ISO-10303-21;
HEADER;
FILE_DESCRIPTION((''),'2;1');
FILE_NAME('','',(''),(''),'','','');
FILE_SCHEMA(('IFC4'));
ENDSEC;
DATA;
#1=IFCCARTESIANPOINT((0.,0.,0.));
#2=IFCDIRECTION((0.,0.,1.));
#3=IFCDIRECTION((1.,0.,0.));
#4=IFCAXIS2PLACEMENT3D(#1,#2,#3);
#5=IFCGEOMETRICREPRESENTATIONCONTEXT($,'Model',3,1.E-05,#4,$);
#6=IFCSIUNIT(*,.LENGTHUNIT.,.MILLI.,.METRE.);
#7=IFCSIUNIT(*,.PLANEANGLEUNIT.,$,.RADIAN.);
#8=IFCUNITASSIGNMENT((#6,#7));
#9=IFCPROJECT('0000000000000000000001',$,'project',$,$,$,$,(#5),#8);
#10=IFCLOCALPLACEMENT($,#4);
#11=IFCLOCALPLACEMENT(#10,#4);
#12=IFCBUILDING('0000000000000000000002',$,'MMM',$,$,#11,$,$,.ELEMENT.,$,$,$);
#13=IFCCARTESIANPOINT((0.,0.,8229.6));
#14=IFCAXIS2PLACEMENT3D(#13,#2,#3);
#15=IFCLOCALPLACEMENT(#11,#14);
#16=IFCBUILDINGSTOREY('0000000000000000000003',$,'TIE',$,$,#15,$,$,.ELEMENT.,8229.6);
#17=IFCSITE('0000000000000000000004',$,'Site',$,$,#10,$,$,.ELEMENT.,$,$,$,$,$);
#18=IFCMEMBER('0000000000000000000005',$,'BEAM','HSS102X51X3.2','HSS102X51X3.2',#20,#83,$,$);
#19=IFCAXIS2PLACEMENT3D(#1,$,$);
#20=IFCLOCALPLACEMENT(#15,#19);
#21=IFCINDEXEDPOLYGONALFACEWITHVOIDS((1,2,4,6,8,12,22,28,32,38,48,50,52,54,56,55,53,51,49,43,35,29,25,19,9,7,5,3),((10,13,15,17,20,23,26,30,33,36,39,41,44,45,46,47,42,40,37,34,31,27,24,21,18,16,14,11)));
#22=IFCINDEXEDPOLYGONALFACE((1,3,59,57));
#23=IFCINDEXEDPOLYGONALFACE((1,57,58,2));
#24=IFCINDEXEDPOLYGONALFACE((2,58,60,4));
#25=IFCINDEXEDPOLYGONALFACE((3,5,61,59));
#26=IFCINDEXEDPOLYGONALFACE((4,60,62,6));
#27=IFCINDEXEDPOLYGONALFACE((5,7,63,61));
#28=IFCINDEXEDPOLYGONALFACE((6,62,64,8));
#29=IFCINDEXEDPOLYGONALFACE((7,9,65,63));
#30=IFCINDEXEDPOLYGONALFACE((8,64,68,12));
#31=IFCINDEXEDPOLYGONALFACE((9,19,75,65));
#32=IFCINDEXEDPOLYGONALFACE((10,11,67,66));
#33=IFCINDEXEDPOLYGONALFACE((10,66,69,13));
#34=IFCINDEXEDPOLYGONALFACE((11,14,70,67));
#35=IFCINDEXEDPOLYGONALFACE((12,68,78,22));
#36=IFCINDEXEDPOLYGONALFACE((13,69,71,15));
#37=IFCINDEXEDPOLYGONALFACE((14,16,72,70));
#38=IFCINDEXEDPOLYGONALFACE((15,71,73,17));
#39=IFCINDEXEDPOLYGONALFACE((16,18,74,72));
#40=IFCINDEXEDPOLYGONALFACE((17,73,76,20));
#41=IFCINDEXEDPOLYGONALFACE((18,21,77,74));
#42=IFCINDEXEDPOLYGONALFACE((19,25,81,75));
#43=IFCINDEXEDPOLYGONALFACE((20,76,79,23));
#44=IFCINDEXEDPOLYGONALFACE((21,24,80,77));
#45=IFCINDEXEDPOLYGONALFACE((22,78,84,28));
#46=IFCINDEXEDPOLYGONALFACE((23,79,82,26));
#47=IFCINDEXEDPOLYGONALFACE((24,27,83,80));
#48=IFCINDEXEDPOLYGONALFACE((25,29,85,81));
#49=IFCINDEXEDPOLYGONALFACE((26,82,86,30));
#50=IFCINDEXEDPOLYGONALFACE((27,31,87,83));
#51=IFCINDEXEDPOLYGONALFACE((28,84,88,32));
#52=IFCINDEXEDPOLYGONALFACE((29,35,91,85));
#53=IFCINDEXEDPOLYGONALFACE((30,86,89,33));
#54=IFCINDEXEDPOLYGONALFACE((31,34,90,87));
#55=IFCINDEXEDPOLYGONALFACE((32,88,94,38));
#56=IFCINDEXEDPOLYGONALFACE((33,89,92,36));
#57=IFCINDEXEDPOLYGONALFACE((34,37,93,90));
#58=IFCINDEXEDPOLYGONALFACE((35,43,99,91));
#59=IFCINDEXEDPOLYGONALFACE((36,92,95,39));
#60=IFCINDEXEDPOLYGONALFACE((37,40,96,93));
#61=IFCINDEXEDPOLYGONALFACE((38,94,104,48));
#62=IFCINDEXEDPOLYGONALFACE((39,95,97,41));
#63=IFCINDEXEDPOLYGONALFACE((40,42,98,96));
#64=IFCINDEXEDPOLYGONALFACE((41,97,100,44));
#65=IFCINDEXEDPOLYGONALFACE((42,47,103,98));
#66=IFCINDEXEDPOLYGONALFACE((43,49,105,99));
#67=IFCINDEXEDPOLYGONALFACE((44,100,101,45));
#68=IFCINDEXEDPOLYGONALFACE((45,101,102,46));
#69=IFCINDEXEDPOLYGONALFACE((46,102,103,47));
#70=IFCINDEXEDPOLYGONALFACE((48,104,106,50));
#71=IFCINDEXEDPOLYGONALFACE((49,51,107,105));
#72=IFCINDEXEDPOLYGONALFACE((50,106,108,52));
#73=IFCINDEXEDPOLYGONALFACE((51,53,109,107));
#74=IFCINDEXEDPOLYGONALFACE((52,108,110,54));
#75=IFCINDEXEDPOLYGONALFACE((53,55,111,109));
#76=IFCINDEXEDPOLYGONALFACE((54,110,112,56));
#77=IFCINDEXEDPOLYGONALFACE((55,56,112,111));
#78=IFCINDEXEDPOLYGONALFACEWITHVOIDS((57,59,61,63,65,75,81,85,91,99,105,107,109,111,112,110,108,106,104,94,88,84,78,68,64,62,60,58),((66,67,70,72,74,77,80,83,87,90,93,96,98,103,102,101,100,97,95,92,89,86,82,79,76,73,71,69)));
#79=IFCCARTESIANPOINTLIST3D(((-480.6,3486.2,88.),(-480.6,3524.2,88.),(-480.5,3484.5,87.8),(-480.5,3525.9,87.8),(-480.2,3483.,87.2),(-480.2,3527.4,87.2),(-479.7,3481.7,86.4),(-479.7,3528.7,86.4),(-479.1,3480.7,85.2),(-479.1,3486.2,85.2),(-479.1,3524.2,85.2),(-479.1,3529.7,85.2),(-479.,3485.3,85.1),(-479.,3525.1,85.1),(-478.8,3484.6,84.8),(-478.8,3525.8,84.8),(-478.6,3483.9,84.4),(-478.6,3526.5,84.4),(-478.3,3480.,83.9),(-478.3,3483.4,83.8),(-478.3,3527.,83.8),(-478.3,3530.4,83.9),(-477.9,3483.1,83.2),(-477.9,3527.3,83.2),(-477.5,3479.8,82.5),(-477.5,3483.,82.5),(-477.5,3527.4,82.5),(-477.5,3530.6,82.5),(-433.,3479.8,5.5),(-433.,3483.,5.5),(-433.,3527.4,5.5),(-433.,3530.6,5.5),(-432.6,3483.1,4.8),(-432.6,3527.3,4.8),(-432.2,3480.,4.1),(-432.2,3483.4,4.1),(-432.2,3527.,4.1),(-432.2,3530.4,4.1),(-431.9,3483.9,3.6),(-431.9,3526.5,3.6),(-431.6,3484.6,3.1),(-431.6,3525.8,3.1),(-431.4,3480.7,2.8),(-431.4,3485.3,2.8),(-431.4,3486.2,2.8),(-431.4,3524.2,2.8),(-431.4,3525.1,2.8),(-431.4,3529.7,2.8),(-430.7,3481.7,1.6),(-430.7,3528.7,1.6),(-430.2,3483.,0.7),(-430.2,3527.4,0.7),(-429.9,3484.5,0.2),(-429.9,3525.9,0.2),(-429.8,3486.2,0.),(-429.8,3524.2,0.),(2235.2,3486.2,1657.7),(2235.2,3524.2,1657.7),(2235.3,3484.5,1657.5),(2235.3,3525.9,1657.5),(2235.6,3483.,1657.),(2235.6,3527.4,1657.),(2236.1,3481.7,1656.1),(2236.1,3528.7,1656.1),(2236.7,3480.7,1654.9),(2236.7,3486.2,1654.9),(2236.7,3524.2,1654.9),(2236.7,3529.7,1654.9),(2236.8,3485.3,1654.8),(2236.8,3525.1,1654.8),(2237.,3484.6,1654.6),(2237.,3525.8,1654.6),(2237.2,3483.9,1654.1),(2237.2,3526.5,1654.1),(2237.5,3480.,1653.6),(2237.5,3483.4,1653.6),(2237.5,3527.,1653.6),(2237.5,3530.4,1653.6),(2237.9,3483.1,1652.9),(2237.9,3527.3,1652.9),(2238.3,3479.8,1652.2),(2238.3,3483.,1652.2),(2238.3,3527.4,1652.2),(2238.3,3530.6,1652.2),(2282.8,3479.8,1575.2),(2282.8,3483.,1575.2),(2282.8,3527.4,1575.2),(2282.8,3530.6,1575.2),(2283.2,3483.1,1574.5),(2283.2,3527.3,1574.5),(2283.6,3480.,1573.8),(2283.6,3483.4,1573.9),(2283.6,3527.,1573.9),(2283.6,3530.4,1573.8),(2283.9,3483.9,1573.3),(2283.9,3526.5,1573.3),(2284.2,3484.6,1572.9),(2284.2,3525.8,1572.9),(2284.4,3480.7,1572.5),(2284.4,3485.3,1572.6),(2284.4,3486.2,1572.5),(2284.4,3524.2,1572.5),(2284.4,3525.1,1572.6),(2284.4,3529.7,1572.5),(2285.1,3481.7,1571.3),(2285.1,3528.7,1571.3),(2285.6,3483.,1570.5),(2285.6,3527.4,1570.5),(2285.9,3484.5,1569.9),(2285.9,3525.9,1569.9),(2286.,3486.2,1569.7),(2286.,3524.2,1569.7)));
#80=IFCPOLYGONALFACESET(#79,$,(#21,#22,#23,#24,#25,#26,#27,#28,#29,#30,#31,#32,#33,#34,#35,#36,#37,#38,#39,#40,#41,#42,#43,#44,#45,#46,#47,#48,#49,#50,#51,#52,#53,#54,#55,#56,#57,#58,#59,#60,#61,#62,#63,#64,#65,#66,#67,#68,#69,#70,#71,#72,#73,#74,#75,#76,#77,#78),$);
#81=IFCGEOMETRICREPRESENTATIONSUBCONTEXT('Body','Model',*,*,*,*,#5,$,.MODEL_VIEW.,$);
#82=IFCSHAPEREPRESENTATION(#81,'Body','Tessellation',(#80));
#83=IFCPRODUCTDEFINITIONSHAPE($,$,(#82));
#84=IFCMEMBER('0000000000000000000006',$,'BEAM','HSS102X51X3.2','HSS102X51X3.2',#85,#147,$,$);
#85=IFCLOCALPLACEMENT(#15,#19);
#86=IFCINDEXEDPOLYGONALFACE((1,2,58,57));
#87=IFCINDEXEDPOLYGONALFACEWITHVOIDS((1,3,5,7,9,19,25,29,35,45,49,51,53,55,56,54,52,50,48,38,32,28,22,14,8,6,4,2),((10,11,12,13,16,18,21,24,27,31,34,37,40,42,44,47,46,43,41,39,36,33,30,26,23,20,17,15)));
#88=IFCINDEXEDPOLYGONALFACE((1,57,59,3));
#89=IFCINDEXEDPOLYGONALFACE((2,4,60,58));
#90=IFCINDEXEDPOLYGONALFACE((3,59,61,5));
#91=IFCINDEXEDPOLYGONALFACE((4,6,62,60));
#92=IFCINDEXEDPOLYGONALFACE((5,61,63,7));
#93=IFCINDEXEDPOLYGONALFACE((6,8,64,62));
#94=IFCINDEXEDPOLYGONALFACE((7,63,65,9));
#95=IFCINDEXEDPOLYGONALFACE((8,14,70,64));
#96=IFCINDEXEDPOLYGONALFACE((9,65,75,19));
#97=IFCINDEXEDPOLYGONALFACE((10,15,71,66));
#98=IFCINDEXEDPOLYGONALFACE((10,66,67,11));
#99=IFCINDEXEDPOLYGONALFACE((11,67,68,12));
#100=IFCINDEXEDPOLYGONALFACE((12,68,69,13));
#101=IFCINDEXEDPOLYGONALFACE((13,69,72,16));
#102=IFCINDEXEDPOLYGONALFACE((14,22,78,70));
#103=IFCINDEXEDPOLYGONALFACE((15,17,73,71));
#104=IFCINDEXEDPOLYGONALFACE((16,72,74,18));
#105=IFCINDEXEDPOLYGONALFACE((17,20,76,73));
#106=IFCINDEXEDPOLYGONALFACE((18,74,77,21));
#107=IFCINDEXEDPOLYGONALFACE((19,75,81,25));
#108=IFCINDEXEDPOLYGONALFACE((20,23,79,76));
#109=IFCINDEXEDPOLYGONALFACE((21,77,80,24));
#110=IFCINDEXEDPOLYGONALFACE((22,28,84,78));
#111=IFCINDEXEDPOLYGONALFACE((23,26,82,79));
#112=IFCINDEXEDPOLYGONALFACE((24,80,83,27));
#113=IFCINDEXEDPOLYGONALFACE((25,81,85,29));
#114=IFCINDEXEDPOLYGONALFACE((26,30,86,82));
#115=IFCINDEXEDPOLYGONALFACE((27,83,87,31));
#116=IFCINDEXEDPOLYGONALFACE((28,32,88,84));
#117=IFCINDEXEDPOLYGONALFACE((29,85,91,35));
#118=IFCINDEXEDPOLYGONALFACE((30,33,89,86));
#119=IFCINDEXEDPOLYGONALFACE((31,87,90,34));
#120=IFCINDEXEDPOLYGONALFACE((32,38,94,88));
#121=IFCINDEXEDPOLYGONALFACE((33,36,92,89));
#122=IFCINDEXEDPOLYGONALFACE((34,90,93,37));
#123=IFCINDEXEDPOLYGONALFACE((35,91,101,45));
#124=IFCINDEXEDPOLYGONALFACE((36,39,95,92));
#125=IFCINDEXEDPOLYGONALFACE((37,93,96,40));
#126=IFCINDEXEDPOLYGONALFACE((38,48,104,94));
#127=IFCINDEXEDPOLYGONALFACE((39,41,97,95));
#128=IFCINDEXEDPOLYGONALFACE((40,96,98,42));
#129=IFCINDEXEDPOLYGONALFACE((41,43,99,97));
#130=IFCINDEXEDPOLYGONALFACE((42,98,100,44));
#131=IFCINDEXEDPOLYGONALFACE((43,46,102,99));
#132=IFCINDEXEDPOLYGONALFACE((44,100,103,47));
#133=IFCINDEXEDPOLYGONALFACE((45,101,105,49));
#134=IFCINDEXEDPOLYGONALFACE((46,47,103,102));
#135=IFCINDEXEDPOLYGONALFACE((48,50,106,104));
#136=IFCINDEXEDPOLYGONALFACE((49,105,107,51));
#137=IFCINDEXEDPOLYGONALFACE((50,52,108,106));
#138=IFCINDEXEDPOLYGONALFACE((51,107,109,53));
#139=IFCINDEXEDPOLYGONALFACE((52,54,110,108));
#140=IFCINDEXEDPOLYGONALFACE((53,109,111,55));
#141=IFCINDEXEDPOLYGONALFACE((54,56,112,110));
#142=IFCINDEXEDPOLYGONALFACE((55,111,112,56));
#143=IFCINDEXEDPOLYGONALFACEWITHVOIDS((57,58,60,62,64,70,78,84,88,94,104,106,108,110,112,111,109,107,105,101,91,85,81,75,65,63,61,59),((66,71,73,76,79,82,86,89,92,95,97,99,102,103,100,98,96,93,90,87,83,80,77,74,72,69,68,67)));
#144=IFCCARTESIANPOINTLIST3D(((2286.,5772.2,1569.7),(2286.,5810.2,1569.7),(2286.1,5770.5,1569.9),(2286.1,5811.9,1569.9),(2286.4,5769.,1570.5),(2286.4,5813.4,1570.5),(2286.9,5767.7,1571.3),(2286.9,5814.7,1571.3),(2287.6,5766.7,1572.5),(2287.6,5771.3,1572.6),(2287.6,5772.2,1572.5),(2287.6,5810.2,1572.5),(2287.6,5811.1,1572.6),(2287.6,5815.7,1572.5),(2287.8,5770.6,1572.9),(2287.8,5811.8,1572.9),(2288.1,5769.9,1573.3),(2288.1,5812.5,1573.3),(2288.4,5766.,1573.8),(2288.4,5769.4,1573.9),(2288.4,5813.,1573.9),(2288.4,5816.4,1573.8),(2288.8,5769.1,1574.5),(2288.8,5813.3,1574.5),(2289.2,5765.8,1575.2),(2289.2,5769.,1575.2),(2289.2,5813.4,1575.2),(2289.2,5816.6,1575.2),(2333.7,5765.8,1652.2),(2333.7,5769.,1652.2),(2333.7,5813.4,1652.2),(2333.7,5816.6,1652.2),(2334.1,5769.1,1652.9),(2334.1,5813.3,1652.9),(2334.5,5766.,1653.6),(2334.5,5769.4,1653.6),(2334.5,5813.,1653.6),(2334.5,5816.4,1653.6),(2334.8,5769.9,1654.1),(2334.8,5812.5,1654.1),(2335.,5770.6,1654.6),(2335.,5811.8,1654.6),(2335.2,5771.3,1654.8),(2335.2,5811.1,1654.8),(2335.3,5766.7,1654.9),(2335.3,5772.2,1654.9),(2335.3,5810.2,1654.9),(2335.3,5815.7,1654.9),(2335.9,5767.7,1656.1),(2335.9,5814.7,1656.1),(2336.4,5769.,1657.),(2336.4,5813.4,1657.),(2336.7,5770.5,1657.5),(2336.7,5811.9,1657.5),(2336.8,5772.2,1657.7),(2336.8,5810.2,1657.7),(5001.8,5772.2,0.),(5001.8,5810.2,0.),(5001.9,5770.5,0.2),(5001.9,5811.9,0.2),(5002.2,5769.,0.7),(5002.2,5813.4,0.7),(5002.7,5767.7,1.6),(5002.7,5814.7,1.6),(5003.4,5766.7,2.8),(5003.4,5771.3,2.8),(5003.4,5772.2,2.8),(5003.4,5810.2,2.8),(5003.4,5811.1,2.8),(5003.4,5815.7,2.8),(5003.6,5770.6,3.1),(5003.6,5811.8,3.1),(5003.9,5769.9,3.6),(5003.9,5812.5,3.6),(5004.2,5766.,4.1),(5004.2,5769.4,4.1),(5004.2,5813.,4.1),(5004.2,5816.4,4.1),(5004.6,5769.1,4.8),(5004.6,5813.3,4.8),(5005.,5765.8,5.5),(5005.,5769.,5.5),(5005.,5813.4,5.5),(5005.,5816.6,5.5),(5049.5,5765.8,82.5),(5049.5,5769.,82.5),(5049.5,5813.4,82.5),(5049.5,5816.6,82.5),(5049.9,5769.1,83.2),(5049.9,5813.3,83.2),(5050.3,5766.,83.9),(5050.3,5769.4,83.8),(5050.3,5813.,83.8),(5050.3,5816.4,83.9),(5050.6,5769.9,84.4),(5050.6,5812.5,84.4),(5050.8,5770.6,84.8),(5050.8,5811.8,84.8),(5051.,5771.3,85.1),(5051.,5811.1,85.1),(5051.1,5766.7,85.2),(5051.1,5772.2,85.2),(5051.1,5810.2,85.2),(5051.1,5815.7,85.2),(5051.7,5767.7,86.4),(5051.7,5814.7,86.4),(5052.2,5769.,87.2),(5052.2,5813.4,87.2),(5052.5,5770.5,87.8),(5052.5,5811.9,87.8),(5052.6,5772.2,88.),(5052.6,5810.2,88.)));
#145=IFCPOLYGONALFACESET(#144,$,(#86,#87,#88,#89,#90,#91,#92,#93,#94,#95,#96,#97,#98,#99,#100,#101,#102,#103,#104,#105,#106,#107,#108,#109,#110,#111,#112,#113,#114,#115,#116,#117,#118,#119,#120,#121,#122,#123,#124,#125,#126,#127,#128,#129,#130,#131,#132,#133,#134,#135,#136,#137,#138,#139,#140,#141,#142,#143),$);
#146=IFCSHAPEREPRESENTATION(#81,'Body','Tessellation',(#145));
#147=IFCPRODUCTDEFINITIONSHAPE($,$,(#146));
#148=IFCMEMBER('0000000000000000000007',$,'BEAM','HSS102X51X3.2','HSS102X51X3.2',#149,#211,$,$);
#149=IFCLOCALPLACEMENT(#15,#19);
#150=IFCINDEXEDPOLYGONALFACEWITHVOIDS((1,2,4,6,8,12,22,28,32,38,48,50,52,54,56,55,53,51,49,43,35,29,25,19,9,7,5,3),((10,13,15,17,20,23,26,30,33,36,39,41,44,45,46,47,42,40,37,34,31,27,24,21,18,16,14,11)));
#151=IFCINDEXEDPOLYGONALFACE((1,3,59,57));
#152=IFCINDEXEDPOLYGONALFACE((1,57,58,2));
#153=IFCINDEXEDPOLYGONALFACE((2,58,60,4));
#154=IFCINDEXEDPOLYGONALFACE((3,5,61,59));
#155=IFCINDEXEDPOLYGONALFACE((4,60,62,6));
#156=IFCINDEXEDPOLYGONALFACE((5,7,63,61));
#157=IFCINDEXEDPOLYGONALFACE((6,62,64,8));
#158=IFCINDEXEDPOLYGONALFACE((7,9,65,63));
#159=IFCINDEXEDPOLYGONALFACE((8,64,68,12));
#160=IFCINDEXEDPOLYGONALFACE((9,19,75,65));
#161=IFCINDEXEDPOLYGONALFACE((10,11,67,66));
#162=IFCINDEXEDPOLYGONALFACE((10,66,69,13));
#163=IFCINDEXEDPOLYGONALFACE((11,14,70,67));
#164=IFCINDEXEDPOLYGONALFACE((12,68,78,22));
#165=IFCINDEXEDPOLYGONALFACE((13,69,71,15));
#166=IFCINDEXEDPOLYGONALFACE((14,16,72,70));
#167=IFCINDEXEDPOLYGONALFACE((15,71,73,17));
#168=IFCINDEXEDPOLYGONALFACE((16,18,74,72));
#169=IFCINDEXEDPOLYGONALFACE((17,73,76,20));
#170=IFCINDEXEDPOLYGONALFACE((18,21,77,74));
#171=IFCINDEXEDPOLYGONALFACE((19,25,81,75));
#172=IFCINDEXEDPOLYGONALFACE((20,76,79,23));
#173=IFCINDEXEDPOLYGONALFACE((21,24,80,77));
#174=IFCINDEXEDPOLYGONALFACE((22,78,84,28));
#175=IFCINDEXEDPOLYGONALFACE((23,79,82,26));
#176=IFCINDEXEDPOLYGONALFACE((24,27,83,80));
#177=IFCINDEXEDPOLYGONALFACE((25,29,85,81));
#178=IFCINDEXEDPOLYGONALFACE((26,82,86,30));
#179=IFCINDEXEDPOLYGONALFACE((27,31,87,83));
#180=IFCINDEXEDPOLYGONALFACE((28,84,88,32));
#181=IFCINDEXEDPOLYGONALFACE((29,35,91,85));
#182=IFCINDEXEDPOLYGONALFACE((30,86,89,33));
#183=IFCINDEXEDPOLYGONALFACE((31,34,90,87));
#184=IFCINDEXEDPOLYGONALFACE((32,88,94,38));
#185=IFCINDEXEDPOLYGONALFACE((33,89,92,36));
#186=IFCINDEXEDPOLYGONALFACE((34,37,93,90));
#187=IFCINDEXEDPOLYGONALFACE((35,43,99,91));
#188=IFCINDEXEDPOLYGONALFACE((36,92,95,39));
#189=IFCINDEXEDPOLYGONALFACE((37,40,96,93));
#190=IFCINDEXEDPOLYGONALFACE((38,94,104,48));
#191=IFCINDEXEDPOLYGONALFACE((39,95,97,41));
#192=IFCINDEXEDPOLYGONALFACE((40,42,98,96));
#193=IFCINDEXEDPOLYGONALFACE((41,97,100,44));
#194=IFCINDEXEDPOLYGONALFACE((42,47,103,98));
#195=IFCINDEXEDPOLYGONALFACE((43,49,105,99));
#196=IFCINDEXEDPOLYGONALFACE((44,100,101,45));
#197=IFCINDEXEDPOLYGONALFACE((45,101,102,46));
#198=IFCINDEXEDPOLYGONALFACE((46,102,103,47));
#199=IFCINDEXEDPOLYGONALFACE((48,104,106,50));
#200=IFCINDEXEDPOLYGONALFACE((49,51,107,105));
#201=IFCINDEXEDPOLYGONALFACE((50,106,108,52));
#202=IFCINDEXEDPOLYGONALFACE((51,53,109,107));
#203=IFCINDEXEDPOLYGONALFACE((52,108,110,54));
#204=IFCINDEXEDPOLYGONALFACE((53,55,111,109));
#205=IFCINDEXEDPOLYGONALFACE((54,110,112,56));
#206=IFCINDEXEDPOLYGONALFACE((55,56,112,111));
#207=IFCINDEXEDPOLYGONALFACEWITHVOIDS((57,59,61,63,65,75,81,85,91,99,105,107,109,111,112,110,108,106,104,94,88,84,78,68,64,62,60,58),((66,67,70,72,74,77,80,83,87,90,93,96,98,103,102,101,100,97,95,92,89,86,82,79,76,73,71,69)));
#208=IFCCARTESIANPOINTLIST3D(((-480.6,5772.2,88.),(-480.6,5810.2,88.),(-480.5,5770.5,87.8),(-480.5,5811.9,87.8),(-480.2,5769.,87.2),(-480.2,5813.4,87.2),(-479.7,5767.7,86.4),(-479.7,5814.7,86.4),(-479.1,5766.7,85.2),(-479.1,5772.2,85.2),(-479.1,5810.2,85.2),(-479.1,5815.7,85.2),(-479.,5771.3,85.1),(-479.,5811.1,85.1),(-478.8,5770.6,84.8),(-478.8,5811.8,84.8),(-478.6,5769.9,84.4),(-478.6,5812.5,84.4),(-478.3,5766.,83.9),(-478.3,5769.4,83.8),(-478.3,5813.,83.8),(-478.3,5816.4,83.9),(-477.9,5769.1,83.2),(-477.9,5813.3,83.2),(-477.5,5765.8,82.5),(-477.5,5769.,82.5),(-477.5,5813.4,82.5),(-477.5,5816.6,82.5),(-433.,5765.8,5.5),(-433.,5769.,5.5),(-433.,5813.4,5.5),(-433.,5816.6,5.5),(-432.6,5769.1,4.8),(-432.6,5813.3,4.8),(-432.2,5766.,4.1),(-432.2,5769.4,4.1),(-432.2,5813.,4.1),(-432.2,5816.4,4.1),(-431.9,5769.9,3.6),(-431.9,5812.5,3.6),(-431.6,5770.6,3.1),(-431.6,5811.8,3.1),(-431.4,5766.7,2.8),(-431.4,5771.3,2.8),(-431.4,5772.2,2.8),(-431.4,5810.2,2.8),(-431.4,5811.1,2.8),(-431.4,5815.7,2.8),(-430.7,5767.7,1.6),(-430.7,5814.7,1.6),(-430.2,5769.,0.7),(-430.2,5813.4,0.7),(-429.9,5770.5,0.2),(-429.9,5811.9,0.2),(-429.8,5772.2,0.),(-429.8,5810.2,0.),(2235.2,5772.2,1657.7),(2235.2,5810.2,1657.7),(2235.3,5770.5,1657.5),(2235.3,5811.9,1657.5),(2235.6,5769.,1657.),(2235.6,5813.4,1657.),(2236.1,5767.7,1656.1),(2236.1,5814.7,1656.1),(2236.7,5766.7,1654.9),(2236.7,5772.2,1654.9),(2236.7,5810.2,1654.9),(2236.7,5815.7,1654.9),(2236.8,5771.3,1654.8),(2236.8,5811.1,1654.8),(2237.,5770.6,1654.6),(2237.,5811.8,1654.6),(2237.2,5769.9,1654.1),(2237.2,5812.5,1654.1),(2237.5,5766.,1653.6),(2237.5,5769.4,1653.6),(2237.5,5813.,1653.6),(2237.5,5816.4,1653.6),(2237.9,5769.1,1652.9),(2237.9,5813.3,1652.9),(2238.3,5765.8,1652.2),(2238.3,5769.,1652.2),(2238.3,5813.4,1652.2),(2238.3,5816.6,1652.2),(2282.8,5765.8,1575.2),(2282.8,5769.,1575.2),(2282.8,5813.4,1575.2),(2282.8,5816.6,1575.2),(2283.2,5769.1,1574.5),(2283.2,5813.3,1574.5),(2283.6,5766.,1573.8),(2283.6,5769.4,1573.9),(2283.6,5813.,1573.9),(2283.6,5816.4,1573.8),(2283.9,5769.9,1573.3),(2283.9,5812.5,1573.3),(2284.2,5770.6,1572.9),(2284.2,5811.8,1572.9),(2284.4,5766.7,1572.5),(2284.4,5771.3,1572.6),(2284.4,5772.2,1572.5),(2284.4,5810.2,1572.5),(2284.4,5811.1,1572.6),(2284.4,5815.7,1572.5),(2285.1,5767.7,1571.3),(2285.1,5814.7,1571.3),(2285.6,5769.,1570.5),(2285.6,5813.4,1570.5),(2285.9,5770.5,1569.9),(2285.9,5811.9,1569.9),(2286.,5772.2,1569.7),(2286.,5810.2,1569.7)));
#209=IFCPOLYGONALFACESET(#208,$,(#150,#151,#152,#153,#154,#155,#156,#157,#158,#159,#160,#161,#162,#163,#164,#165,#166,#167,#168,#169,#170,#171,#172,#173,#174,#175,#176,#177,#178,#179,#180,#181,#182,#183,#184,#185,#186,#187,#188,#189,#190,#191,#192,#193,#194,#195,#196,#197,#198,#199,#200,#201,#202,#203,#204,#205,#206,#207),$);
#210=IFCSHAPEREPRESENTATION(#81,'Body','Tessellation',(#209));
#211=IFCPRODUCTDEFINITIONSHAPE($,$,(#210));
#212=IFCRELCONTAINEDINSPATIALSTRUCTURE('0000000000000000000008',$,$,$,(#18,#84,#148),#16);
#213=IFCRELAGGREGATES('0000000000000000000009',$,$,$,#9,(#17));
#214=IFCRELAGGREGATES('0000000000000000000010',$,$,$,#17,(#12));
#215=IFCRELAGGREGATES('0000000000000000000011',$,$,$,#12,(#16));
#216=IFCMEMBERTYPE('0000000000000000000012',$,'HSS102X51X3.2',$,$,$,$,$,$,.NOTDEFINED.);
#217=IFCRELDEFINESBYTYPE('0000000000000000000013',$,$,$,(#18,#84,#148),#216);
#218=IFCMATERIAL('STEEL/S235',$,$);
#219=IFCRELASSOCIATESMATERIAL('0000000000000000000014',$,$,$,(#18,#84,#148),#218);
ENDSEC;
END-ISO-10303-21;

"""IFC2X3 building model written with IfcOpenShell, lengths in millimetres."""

from ifc_helpers import new_model, si_unit, frame, origin_with_axes, origin_2d_with_axis, place, context, subcontext, project, spatial, hollow_rectangle, extrude, material, type_object, element, save


model = new_model("IFC2X3")

# Units and contexts
model_context = context("Model", 3, precision=1e-05, world=origin_with_axes())
body_context = subcontext(model_context, "Body", "Model", "MODEL_VIEW")
ifc_project = project(units=[si_unit("LENGTHUNIT", "METRE", prefix="MILLI"), si_unit("PLANEANGLEUNIT", "RADIAN")], contexts=[model_context])

# Site, building, storey
site_placement = place(None, origin_with_axes())
site = spatial("IfcSite", under=ifc_project, at=site_placement, Name="Site", CompositionType="ELEMENT")
building_placement = place(site_placement, origin_with_axes())
building = spatial("IfcBuilding", under=site, at=building_placement, Name="MMM", CompositionType="ELEMENT")
storey_placement = place(building_placement, frame((0.0, 0.0, 8229.6), z_axis=(0.0, 0.0, 1.0), x_axis=(1.0, 0.0, 0.0)))
storey = spatial("IfcBuildingStorey", under=building, at=storey_placement, Name="TIE", CompositionType="ELEMENT", Elevation=8229.6)

# Shared definitions
ifc_material = material(Name="STEEL/S235")

# Members
member_type_1 = type_object("IfcMemberType", Name="HSS102X51X3.2", PredefinedType="NOTDEFINED")
for number, where, z_axis, x_axis, name in (
    (1, (2260.6, 3505.2, 1613.7), (-0.500422, 0.0, 0.865782), (-0.865782, 0.0, -0.500422), "BEAM"),
    (2, (2311.4, 5791.2, 1613.7), (0.500422, 0.0, 0.865782), (0.865782, 0.0, -0.500422), "BEAM"),
    (3, (2260.6, 5791.2, 1613.7), (-0.500422, 0.0, 0.865782), (-0.865782, 0.0, -0.500422), "BEAM"),
):
    element("IfcMember", number, at=place(storey_placement, frame(where, z_axis=z_axis, x_axis=x_axis)), inside=storey, type_object=member_type_1, material=ifc_material, Name=name, Description="HSS102X51X3.2", ObjectType="HSS102X51X3.2", context=body_context, shape_type="SweptSolid", body=[
        extrude(hollow_rectangle(XDim=50.8, YDim=101.6, WallThickness=3.2, InnerFilletRadius=3.2, OuterFilletRadius=6.4, at=origin_2d_with_axis()), frame((3136.8, 0.0, 0.0), z_axis=(-1.0, 0.0, 0.0), x_axis=(0.0, -1.0, 0.0)), (0.0, 0.0, 1.0), 3136.8),
    ])

save(model, "model.ifc")
